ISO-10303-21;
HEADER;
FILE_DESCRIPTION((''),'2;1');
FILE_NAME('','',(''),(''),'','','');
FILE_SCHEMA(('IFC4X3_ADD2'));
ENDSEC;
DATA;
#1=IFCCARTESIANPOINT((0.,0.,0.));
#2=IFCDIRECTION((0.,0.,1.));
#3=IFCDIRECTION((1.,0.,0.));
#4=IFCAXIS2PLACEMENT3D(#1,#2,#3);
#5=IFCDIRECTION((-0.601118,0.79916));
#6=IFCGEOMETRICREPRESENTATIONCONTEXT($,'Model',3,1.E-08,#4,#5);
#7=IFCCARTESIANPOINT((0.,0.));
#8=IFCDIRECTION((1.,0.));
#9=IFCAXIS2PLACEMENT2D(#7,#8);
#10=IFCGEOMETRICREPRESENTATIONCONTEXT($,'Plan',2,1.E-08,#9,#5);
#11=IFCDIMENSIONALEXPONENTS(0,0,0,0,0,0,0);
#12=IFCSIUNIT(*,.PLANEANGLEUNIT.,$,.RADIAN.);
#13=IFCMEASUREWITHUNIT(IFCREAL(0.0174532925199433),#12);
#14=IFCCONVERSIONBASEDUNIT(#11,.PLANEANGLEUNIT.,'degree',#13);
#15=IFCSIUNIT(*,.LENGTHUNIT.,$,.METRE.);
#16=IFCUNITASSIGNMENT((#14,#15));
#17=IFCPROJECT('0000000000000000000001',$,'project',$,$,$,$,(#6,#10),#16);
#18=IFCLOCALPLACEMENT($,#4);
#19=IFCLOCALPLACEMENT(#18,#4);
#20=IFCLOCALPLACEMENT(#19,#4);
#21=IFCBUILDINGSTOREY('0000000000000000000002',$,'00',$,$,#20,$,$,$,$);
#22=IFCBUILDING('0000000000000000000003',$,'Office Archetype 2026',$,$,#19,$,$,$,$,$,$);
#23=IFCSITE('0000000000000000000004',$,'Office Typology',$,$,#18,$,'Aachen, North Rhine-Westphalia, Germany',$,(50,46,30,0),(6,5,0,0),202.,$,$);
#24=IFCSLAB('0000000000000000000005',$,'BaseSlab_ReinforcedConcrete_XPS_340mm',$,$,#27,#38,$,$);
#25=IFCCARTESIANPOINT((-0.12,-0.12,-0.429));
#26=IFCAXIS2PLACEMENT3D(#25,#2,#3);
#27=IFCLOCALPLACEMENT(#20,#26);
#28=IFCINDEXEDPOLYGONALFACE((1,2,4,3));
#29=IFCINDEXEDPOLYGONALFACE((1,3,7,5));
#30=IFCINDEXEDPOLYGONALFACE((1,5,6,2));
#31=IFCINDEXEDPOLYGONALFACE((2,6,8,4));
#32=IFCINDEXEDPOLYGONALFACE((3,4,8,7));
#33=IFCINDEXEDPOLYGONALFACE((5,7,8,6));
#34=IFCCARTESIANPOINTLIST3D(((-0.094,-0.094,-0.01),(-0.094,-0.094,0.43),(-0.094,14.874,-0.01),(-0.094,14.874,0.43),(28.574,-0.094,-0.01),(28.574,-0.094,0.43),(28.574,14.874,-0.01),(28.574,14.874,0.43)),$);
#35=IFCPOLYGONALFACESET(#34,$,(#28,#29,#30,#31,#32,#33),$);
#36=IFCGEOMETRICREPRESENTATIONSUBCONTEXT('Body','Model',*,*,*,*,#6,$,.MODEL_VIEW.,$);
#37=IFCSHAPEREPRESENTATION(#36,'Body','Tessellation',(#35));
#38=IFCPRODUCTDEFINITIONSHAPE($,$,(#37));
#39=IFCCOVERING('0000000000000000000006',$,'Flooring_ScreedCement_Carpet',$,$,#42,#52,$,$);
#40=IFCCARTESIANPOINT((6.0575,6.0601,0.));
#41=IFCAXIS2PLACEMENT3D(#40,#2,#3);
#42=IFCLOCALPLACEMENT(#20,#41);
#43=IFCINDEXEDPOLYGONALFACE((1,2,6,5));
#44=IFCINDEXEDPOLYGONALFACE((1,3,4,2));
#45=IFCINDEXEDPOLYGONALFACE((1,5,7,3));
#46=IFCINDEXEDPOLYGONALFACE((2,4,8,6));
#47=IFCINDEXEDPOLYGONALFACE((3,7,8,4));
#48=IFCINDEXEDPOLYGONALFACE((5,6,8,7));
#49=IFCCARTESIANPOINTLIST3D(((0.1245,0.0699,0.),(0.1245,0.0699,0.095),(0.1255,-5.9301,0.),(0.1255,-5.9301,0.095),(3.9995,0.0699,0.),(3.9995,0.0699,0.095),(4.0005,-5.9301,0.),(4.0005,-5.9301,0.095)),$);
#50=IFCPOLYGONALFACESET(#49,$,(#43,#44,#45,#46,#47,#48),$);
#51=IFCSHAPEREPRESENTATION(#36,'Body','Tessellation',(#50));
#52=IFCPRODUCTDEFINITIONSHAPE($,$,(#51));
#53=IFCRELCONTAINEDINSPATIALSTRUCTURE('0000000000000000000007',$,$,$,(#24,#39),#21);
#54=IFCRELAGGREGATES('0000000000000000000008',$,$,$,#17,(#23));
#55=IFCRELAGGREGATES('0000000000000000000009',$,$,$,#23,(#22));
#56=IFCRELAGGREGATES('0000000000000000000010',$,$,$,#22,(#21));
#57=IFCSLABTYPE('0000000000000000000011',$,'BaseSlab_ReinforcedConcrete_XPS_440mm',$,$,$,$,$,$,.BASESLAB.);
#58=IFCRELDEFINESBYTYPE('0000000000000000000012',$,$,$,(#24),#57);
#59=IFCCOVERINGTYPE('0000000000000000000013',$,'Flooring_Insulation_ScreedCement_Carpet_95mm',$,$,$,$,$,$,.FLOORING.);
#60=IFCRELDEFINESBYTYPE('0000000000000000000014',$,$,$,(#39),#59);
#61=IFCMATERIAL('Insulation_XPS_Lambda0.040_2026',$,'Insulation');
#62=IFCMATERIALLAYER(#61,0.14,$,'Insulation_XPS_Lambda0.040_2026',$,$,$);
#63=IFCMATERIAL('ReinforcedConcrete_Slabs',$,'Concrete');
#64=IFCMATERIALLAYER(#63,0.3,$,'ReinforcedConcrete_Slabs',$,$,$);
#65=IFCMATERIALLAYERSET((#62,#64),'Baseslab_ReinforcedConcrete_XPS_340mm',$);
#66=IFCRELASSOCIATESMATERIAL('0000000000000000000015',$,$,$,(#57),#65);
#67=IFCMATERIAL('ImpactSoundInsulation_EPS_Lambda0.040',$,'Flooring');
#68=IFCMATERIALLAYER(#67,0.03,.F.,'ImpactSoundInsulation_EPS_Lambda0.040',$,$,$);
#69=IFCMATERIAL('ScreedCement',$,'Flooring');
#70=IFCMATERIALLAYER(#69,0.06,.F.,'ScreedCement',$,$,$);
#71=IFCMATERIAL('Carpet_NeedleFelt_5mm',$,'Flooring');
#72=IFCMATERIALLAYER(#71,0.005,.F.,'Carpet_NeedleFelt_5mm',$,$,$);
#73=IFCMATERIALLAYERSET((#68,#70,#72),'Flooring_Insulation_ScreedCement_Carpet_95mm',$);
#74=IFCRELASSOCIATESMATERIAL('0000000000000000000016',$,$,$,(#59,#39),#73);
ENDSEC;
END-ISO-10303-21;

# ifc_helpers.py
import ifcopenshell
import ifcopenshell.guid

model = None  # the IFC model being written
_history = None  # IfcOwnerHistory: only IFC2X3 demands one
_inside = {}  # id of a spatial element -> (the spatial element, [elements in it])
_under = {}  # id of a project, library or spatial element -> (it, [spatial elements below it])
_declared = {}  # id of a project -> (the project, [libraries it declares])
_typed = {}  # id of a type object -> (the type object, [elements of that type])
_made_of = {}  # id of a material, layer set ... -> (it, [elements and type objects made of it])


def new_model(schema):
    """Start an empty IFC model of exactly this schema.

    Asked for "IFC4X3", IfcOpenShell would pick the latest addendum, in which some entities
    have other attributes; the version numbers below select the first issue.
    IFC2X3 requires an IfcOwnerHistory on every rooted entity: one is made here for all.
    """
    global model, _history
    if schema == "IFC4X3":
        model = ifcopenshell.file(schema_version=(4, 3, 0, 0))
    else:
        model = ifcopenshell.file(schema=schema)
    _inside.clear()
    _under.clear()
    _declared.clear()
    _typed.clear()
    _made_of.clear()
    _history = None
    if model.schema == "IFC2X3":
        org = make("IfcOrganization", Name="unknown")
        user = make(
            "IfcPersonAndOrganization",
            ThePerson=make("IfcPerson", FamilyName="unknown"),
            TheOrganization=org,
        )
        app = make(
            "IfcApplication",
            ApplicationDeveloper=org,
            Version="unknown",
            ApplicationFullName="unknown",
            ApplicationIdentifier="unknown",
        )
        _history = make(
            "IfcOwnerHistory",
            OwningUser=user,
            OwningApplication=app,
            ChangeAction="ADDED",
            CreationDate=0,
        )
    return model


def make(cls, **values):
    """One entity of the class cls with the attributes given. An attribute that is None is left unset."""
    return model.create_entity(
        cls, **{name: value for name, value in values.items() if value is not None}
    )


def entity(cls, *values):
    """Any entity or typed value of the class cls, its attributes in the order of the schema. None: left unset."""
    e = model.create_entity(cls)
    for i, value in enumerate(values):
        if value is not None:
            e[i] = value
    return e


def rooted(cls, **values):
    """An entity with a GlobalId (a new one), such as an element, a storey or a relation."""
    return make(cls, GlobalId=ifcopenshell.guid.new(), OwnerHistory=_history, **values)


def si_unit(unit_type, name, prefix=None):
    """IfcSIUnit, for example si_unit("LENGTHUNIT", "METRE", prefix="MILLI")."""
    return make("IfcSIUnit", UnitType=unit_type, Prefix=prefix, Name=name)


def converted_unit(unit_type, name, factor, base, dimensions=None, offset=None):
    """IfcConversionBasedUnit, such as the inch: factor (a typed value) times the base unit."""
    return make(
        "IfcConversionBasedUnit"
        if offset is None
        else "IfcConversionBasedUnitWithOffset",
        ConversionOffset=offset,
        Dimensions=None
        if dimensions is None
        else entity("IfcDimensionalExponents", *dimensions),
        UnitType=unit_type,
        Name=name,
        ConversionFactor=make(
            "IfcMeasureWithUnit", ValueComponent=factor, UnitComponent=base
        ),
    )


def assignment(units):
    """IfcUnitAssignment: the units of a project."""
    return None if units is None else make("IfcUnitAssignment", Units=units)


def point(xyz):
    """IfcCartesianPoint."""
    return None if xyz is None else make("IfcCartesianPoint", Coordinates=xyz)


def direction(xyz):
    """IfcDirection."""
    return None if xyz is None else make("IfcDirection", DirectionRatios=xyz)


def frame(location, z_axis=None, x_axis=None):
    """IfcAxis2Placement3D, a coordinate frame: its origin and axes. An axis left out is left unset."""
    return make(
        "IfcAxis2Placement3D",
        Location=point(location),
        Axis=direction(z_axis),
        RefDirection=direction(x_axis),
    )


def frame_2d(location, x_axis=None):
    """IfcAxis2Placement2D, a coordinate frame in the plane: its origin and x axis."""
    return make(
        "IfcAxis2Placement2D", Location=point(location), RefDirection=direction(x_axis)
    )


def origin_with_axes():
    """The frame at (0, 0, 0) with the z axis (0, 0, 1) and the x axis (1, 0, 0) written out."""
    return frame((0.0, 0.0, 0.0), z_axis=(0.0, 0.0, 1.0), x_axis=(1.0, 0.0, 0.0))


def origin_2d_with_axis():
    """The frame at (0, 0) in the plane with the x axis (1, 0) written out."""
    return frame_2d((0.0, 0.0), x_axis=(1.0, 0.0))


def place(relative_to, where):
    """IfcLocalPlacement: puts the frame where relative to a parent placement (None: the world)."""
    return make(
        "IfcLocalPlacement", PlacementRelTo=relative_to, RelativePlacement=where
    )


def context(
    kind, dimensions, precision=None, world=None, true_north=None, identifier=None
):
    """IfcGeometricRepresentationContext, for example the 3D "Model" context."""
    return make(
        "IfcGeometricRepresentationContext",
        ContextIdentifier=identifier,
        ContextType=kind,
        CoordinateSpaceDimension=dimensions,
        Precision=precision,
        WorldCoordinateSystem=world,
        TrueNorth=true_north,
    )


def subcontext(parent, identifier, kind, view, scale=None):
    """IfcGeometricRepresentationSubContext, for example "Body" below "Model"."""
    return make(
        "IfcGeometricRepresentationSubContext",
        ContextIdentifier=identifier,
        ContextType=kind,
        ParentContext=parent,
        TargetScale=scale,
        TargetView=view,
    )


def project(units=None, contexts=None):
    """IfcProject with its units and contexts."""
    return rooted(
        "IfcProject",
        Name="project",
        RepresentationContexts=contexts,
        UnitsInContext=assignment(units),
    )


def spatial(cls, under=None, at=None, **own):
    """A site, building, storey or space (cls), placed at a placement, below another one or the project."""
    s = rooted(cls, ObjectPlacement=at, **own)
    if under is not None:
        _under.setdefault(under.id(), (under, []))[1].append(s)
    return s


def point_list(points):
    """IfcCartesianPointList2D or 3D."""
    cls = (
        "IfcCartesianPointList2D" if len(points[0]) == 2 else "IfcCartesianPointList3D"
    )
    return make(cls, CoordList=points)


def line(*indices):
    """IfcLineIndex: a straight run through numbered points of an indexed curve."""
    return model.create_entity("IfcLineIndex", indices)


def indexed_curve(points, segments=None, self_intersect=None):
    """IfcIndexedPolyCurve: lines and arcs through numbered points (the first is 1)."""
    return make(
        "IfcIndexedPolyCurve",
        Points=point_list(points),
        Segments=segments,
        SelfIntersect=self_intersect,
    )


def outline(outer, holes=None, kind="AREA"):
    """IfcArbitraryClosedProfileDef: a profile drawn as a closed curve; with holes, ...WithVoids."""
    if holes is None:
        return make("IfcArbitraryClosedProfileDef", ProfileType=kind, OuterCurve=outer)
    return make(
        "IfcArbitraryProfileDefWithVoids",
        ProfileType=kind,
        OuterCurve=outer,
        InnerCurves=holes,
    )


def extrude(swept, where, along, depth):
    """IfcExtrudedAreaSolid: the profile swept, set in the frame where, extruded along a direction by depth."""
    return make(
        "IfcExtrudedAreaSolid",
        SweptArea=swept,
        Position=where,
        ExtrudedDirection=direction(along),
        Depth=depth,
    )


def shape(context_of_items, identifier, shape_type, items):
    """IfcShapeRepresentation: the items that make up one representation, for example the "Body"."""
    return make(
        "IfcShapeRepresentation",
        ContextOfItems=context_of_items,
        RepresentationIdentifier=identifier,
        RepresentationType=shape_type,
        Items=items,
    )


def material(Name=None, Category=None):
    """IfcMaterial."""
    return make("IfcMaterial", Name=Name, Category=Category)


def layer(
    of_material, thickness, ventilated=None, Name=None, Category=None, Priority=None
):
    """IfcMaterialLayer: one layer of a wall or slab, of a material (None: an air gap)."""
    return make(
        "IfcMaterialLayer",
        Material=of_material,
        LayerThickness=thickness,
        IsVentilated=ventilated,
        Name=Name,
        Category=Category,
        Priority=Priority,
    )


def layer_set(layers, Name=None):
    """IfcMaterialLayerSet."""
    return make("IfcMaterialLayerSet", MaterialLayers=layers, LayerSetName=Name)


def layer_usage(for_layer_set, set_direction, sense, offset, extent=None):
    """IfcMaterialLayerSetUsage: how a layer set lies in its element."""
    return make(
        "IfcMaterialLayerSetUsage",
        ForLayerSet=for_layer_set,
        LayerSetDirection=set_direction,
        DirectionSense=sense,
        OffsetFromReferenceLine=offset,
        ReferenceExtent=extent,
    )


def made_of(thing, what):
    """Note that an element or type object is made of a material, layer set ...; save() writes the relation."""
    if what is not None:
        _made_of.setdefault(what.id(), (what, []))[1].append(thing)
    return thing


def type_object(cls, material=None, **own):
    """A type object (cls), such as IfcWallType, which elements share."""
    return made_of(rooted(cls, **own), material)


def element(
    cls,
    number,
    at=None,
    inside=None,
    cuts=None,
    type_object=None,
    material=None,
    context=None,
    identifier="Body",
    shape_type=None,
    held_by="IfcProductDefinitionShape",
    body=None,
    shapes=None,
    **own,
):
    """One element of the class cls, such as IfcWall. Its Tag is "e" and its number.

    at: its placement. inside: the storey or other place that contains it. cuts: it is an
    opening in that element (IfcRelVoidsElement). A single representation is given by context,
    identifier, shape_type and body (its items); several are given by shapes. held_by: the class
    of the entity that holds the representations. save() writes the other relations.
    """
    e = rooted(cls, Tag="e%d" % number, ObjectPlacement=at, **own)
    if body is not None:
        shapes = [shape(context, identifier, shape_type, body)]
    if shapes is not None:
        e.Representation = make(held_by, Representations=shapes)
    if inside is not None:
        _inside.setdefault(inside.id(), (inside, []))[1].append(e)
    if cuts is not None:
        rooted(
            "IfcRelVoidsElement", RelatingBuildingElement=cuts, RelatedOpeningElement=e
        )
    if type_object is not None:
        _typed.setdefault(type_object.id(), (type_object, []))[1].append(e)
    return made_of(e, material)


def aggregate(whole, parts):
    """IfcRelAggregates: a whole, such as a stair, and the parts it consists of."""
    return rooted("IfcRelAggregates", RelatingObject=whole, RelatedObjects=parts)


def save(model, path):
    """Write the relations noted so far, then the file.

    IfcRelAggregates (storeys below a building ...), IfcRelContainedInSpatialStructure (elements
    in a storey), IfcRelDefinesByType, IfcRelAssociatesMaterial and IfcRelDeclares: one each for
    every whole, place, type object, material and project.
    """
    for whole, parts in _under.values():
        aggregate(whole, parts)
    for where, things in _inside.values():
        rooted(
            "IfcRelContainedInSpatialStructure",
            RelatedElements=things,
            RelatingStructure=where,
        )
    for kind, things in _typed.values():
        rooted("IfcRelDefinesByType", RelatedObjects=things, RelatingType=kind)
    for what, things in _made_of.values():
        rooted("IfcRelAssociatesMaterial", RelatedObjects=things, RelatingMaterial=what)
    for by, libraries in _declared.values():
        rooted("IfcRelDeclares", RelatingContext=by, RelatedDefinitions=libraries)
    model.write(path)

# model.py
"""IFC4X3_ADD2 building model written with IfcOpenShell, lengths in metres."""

from ifc_helpers import new_model, entity, si_unit, converted_unit, direction, frame, origin_with_axes, origin_2d_with_axis, place, context, subcontext, project, spatial, line, indexed_curve, outline, extrude, material, layer, layer_set, layer_usage, type_object, element, save


model = new_model("IFC4X3_ADD2")

# Units and contexts
model_context = context("Model", 3, precision=1e-08, world=origin_with_axes(), true_north=direction((-0.601118, 0.79916)))
plan_context = context("Plan", 2, precision=1e-08, world=origin_2d_with_axis(), true_north=direction((-0.601118, 0.79916)))
body_context = subcontext(model_context, "Body", "Model", "MODEL_VIEW")
ifc_project = project(units=[converted_unit("PLANEANGLEUNIT", "degree", entity("IfcReal", 0.0174532925199433), si_unit("PLANEANGLEUNIT", "RADIAN"), dimensions=[0, 0, 0, 0, 0, 0, 0]), si_unit("LENGTHUNIT", "METRE")], contexts=[model_context, plan_context])

# Site, building, storey
site_placement = place(None, origin_with_axes())
site = spatial("IfcSite", under=ifc_project, at=site_placement, Name="Office Typology", LongName="Aachen, North Rhine-Westphalia, Germany", RefLatitude=(50, 46, 30, 0), RefLongitude=(6, 5, 0, 0), RefElevation=202.0)
building_placement = place(site_placement, origin_with_axes())
building = spatial("IfcBuilding", under=site, at=building_placement, Name="Office Archetype 2026")
storey_placement = place(building_placement, origin_with_axes())
storey = spatial("IfcBuildingStorey", under=building, at=storey_placement, Name="00")

# Slab
ifc_material_1 = material(Name="Insulation_XPS_Lambda0.040_2026", Category="Insulation")
ifc_layer_1 = layer(ifc_material_1, 0.14, Name="Insulation_XPS_Lambda0.040_2026")
ifc_material_2 = material(Name="ReinforcedConcrete_Slabs", Category="Concrete")
ifc_layer_2 = layer(ifc_material_2, 0.3, Name="ReinforcedConcrete_Slabs")
ifc_layer_set_1 = layer_set([ifc_layer_1, ifc_layer_2], Name="Baseslab_ReinforcedConcrete_XPS_340mm")
slab_type = type_object("IfcSlabType", Name="BaseSlab_ReinforcedConcrete_XPS_440mm", PredefinedType="BASESLAB", material=ifc_layer_set_1)
slab_placement = place(storey_placement, frame((-0.12, -0.12, -0.429), z_axis=(0.0, 0.0, 1.0), x_axis=(1.0, 0.0, 0.0)))
element("IfcSlab", 1, at=slab_placement, inside=storey, type_object=slab_type, Name="BaseSlab_ReinforcedConcrete_XPS_340mm", context=body_context, shape_type="SweptSolid", body=[
    extrude(outline(indexed_curve([(-0.094, -0.094), (28.574, -0.094), (28.574, 14.874), (-0.094, 14.874), (-0.094, -0.094)])), frame((0.0, 0.0, -0.01), z_axis=(0.0, 0.0, 1.0), x_axis=(1.0, 0.0, 0.0)), (0.0, 0.0, 1.0), 0.44),
])

# Covering
ifc_material_3 = material(Name="ImpactSoundInsulation_EPS_Lambda0.040", Category="Flooring")
ifc_layer_3 = layer(ifc_material_3, 0.03, ventilated=False, Name="ImpactSoundInsulation_EPS_Lambda0.040")
ifc_material_4 = material(Name="ScreedCement", Category="Flooring")
ifc_layer_4 = layer(ifc_material_4, 0.06, ventilated=False, Name="ScreedCement")
ifc_material_5 = material(Name="Carpet_NeedleFelt_5mm", Category="Flooring")
ifc_layer_5 = layer(ifc_material_5, 0.005, ventilated=False, Name="Carpet_NeedleFelt_5mm")
ifc_layer_set_2 = layer_set([ifc_layer_3, ifc_layer_4, ifc_layer_5], Name="Flooring_Insulation_ScreedCement_Carpet_95mm")
ifc_layer_usage_1 = layer_usage(ifc_layer_set_2, "AXIS3", "POSITIVE", 0.0)
covering_type_1 = type_object("IfcCoveringType", Name="Flooring_Insulation_ScreedCement_Carpet_95mm", PredefinedType="FLOORING", material=ifc_layer_set_2)
covering_1_placement = place(storey_placement, frame((6.0575, 6.0601, 0.0), z_axis=(0.0, 0.0, 1.0), x_axis=(1.0, 0.0, 0.0)))
element("IfcCovering", 2, at=covering_1_placement, inside=storey, type_object=covering_type_1, material=ifc_layer_usage_1, Name="Flooring_ScreedCement_Carpet", context=body_context, shape_type="SweptSolid", body=[
    extrude(outline(indexed_curve([(0.1255, -5.9301), (0.1245, 0.0699), (3.9995, 0.0699), (4.0005, -5.9301)], segments=[line(1, 2, 3, 4, 1)])), origin_with_axes(), (0.0, 0.0, 1.0), 0.095),
])

save(model, "model.ifc")
